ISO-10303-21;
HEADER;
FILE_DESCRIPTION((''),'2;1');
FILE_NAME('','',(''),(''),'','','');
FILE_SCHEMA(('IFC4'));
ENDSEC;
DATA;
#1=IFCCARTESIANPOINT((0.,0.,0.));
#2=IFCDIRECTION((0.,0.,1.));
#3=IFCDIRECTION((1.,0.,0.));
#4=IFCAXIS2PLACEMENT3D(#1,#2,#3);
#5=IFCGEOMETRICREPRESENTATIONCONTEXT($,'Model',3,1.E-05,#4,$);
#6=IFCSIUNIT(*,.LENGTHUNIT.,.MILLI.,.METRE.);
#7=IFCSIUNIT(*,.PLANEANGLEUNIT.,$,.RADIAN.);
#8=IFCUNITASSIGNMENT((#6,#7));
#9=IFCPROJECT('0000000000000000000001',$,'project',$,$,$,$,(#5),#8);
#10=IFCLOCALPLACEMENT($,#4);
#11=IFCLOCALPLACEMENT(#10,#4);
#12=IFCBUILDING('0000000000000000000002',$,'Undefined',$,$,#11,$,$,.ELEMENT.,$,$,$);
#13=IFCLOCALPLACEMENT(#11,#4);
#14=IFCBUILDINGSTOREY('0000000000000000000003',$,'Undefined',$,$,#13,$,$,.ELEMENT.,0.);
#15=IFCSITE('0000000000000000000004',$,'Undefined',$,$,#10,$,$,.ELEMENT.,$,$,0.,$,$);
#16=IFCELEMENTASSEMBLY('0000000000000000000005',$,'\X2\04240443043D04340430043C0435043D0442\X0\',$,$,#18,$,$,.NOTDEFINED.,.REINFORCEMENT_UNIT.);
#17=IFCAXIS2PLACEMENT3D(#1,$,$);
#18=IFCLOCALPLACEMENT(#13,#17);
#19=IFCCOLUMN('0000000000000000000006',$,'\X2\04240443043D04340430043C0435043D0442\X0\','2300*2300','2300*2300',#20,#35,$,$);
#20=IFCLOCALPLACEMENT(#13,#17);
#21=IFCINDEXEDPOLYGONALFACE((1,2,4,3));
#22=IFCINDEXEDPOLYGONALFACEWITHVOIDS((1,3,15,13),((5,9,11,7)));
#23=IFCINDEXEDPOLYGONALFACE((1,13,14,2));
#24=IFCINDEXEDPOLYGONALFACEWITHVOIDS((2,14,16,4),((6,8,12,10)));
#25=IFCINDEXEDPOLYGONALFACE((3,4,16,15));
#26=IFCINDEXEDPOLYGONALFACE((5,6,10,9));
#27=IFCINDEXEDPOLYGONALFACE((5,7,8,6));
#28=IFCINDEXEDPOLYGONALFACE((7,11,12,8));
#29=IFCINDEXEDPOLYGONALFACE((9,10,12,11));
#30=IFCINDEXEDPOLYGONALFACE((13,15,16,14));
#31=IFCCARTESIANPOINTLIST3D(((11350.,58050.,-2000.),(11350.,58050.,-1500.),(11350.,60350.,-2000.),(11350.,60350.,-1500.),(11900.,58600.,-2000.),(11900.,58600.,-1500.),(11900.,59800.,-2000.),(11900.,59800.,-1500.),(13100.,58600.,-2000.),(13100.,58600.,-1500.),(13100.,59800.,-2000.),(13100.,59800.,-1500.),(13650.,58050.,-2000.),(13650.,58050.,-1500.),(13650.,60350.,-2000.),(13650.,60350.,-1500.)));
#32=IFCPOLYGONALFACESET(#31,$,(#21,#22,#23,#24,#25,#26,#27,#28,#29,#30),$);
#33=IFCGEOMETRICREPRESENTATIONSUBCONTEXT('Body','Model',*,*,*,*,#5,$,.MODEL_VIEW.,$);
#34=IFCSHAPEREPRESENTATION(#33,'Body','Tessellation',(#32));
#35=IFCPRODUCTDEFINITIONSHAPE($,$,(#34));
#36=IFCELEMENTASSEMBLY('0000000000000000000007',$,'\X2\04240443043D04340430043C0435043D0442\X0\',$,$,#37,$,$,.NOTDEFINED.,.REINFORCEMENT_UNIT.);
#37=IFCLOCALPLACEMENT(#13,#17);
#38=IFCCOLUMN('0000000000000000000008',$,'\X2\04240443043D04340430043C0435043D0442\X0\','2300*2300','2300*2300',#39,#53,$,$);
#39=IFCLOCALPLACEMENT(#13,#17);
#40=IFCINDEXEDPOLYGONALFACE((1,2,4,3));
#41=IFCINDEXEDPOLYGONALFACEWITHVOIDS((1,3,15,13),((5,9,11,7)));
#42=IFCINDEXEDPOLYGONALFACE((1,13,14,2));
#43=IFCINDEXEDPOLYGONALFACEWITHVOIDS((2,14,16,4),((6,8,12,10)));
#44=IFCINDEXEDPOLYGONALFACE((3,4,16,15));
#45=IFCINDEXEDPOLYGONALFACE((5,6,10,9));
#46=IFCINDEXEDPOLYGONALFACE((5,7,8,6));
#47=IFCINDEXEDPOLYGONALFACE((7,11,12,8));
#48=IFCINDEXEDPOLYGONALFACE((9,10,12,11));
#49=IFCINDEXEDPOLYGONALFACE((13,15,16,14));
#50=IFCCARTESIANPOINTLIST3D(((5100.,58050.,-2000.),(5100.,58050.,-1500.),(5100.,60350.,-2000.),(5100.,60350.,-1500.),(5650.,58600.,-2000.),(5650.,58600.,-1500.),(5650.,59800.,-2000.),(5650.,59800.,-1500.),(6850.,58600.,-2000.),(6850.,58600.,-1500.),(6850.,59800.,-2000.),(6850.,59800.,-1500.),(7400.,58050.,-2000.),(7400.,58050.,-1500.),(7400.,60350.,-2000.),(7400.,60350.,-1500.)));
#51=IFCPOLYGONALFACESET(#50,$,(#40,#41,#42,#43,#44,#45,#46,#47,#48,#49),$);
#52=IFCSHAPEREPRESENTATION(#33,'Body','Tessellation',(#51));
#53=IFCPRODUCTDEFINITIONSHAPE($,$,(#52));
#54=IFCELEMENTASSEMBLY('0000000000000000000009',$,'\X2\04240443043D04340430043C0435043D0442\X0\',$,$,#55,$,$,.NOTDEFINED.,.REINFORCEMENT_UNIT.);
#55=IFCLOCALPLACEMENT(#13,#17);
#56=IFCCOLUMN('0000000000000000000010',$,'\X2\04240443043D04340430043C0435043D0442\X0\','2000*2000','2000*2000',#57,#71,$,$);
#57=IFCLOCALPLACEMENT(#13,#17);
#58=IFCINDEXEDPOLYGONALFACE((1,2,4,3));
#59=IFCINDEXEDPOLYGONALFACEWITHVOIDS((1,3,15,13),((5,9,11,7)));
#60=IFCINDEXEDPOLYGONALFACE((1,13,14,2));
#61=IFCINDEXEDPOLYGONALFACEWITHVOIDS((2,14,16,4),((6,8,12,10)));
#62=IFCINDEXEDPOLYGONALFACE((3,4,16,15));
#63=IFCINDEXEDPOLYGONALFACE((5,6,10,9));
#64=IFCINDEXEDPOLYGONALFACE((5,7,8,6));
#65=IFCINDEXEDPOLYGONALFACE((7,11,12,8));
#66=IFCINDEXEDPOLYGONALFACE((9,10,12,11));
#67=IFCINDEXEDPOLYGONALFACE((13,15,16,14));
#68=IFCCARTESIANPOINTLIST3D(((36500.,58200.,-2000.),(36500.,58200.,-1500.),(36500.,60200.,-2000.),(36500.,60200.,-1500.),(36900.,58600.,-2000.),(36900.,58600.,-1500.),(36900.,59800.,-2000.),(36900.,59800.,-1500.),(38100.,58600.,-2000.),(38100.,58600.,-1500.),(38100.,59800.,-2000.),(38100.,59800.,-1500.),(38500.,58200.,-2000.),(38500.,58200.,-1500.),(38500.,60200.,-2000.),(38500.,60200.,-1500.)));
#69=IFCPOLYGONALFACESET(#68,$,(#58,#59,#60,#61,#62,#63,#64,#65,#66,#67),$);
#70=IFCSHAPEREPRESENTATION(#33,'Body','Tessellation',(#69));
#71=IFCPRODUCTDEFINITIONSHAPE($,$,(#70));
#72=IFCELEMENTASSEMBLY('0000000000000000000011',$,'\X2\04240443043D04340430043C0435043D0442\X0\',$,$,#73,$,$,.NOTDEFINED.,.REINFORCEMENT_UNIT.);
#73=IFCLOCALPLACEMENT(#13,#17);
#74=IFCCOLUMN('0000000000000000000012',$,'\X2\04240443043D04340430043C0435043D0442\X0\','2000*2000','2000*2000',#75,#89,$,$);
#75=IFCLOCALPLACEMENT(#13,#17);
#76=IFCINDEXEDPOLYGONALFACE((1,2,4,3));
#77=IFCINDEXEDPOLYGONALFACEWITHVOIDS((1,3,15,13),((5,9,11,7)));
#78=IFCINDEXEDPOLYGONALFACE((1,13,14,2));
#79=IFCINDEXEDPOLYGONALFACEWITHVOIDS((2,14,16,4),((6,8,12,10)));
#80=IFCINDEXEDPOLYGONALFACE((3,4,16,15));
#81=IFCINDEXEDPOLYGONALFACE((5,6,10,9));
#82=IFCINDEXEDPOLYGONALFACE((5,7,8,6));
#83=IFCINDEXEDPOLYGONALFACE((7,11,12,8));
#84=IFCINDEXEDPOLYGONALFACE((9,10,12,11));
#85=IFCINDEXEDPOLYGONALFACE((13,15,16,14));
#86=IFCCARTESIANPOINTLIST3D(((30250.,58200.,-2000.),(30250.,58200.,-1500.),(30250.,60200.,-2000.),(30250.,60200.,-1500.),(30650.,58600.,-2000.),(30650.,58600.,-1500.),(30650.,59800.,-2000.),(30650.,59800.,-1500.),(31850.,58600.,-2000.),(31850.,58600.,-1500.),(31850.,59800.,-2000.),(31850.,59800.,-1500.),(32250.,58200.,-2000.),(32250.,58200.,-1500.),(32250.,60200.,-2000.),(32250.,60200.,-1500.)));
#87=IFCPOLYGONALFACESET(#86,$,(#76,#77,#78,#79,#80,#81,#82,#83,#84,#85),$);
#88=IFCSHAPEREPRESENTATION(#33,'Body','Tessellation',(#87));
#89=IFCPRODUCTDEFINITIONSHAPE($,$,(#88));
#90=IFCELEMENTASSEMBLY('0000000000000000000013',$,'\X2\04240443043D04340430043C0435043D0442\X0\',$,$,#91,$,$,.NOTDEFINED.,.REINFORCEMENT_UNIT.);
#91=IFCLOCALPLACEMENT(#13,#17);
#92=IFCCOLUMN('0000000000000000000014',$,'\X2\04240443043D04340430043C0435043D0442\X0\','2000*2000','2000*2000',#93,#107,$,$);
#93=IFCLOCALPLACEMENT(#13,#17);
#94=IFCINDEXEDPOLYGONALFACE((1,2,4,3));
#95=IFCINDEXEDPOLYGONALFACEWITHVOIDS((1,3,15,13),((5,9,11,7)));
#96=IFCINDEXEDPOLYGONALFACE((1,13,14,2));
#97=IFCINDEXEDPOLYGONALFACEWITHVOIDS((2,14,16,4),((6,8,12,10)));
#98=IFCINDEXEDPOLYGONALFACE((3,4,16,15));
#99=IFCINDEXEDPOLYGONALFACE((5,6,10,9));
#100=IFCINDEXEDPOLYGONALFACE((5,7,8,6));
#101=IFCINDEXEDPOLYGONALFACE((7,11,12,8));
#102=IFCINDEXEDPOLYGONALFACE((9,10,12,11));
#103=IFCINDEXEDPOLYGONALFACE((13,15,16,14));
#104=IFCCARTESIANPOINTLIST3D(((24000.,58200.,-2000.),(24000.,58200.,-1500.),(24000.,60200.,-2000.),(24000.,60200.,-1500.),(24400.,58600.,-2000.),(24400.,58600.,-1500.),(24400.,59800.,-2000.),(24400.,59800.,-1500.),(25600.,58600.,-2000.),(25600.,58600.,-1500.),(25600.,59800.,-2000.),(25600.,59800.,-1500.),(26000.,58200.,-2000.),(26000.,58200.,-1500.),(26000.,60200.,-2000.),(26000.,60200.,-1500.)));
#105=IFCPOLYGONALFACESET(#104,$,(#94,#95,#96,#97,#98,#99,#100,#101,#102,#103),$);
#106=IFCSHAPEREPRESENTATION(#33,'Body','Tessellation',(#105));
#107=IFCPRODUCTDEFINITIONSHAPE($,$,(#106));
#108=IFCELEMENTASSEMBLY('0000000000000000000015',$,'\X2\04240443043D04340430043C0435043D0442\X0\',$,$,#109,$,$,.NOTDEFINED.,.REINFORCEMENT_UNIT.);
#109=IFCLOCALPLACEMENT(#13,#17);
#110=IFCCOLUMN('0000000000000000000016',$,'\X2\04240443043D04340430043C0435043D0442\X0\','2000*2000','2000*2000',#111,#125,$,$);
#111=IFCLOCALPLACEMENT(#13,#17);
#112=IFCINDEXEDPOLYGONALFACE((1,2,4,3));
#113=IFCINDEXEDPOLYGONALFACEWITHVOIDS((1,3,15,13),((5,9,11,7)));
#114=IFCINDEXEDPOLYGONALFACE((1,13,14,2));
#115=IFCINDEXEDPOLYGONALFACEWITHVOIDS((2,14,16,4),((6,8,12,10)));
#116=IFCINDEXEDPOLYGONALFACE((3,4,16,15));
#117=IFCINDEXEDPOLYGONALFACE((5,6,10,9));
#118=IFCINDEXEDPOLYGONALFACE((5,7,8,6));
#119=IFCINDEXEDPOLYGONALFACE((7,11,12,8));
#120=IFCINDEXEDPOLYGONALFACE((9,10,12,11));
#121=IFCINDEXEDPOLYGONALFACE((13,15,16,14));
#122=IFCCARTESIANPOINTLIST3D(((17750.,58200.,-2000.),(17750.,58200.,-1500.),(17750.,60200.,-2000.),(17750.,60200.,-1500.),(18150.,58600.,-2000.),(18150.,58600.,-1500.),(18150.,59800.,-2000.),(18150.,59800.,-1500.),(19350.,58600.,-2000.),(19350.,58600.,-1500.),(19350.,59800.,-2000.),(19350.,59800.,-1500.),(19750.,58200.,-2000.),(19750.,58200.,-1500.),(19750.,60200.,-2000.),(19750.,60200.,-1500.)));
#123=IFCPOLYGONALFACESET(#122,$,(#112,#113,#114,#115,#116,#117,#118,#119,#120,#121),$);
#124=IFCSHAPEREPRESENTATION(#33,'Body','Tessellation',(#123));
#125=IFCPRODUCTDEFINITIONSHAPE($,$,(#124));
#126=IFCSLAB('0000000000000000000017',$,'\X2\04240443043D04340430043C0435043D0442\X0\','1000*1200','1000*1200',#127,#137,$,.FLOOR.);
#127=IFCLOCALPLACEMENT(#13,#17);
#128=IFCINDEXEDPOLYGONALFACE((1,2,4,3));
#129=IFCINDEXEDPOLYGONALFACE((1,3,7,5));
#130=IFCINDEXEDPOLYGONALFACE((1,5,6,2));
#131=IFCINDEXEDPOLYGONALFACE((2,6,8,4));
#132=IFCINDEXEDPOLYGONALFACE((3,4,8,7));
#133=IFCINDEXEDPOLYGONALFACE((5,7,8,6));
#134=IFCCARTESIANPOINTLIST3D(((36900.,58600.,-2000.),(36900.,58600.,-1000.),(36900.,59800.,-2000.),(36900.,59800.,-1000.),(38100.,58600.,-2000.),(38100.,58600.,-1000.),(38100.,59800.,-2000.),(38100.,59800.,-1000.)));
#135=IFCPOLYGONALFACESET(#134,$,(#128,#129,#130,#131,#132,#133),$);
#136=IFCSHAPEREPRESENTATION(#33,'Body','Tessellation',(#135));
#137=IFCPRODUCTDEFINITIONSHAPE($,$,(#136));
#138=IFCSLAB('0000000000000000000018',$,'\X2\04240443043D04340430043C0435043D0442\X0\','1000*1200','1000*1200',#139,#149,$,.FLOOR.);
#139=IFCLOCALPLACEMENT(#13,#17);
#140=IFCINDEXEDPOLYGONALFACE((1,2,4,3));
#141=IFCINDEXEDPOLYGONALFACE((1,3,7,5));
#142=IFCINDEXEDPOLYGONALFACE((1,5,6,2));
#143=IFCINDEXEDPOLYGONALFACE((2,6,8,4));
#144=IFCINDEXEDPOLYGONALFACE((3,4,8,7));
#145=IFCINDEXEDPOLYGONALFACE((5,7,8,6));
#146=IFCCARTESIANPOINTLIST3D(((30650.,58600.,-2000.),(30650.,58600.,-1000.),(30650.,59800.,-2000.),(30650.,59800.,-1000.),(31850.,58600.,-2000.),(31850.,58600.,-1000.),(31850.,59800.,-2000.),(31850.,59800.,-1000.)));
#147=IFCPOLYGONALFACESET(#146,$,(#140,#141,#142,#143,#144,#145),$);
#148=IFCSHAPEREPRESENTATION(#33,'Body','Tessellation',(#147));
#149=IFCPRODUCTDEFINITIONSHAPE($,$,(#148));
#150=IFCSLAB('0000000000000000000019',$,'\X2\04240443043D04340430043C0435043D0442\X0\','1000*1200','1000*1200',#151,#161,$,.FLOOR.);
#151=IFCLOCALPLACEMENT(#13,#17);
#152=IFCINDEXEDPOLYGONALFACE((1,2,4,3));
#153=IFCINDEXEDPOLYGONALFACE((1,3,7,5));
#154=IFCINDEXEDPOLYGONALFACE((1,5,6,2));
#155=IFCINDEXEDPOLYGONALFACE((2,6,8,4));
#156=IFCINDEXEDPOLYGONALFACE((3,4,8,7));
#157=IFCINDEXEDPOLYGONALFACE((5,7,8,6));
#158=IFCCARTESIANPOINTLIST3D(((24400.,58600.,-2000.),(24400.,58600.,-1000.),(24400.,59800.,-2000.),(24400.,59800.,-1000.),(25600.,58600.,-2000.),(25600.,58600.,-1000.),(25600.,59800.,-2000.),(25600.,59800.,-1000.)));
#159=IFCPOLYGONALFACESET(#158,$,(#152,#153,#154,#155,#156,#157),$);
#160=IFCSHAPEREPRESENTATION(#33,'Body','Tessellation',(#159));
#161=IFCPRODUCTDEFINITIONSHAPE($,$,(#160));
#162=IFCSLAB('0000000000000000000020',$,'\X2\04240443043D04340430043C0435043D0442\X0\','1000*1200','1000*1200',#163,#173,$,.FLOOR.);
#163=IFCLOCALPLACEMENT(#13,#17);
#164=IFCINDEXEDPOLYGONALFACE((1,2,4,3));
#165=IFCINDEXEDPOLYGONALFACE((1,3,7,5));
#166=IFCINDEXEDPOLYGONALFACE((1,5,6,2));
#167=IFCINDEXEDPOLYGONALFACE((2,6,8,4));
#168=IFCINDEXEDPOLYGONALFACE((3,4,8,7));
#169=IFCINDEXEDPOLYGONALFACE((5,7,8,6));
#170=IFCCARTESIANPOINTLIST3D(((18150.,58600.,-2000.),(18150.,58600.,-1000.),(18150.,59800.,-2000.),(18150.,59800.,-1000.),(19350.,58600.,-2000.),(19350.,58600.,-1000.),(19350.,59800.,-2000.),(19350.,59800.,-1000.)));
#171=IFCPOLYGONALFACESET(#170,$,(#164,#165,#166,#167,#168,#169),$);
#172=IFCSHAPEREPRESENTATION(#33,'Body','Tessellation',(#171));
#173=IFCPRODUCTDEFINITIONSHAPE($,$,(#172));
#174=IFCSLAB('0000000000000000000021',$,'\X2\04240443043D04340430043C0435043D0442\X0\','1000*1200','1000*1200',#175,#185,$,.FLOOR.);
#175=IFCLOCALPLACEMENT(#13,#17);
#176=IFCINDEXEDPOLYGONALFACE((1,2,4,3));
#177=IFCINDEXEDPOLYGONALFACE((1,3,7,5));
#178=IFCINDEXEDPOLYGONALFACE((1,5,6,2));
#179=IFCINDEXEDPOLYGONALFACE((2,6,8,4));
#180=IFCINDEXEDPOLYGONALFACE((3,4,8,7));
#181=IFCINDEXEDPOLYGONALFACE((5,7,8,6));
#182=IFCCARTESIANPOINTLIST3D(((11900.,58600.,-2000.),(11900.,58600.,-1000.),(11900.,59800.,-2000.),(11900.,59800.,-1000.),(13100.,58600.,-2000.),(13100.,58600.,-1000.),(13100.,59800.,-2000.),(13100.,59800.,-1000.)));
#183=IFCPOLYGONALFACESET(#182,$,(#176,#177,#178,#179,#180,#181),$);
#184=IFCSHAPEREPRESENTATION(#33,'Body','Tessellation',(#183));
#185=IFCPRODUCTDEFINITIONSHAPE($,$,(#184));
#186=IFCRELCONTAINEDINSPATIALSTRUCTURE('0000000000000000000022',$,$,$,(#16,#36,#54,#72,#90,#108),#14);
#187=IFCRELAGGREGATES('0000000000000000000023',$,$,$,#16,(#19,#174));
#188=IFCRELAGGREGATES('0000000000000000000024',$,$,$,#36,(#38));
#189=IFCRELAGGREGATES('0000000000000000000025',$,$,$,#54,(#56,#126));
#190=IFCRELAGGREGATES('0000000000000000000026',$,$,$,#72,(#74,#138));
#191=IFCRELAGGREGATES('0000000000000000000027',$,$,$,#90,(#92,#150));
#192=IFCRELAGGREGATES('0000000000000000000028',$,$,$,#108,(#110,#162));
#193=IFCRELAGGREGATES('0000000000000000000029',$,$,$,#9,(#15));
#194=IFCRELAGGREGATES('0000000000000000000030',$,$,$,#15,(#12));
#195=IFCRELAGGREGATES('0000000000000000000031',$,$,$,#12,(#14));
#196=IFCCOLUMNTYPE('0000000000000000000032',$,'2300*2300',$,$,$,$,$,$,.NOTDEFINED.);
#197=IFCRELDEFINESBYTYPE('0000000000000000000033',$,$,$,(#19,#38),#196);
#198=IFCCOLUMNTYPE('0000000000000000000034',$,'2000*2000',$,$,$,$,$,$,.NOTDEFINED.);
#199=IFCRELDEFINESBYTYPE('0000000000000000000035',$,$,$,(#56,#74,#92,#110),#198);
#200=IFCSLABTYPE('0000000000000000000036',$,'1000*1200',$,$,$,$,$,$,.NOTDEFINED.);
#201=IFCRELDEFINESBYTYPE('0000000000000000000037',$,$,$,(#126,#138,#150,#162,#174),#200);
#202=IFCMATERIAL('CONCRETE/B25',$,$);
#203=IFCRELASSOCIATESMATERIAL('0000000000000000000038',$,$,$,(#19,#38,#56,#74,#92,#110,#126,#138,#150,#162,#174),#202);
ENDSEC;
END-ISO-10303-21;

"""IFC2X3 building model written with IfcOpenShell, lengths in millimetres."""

from ifc_helpers import new_model, si_unit, frame, origin_with_axes, origin_2d_with_axis, place, context, subcontext, project, spatial, polyline, rectangle, outline, extrude, boolean, material, type_object, element, aggregate, save


model = new_model("IFC2X3")

# Units and contexts
model_context = context("Model", 3, precision=1e-05, world=origin_with_axes())
body_context = subcontext(model_context, "Body", "Model", "MODEL_VIEW")
ifc_project = project(units=[si_unit("LENGTHUNIT", "METRE", prefix="MILLI"), si_unit("PLANEANGLEUNIT", "RADIAN")], contexts=[model_context])

# Site, building, storey
site_placement = place(None, origin_with_axes())
site = spatial("IfcSite", under=ifc_project, at=site_placement, Name="Undefined", CompositionType="ELEMENT", RefElevation=0.0)
building_placement = place(site_placement, origin_with_axes())
building = spatial("IfcBuilding", under=site, at=building_placement, Name="Undefined", CompositionType="ELEMENT")
storey_placement = place(building_placement, origin_with_axes())
storey = spatial("IfcBuildingStorey", under=building, at=storey_placement, Name="Undefined", CompositionType="ELEMENT", Elevation=0.0)

# Element assemblies, columns
assembly_1_placement = place(storey_placement, origin_with_axes())
assembly_1 = element("IfcElementAssembly", 1, at=assembly_1_placement, inside=storey, Name="Фундамент", AssemblyPlace="NOTDEFINED", PredefinedType="REINFORCEMENT_UNIT")
ifc_material_1 = material(Name="CONCRETE/B25")
column_type_1 = type_object("IfcColumnType", Name="2300*2300", PredefinedType="NOTDEFINED")
column_1_placement = place(assembly_1_placement, frame((12500.0, 59200.0, -2000.0), z_axis=(0.0, 0.0, 1.0), x_axis=(0.0, -1.0, 0.0)))
column_1 = element("IfcColumn", 2, at=column_1_placement, type_object=column_type_1, material=ifc_material_1, Name="Фундамент", Description="2300*2300", ObjectType="2300*2300", context=body_context, shape_type="CSG", body=[
    boolean("DIFFERENCE", extrude(rectangle(XDim=2300.0, YDim=2300.0, at=origin_2d_with_axis()), frame((0.0, 0.0, 500.0), z_axis=(0.0, 0.0, -1.0), x_axis=(0.0, 1.0, 0.0)), (0.0, 0.0, 1.0), 500.0), extrude(outline(polyline([(0.0, 0.0), (1200.0, 0.0), (1200.0, 1200.0), (0.0, 1200.0), (0.0, 0.0)])), frame((-600.0, -600.0, -100.0), z_axis=(0.0, 0.0, 1.0), x_axis=(1.0, 0.0, 0.0)), (0.0, 0.0, 1.0), 700.0)),
])
assembly_2_placement = place(storey_placement, origin_with_axes())
assembly_2 = element("IfcElementAssembly", 3, at=assembly_2_placement, inside=storey, Name="Фундамент", AssemblyPlace="NOTDEFINED", PredefinedType="REINFORCEMENT_UNIT")
column_2_placement = place(assembly_2_placement, frame((6250.0, 59200.0, -2000.0), z_axis=(0.0, 0.0, 1.0), x_axis=(0.0, -1.0, 0.0)))
column_2 = element("IfcColumn", 4, at=column_2_placement, type_object=column_type_1, material=ifc_material_1, Name="Фундамент", Description="2300*2300", ObjectType="2300*2300", context=body_context, shape_type="CSG", body=[
    boolean("DIFFERENCE", extrude(rectangle(XDim=2300.0, YDim=2300.0, at=origin_2d_with_axis()), frame((0.0, 0.0, 500.0), z_axis=(0.0, 0.0, -1.0), x_axis=(0.0, 1.0, 0.0)), (0.0, 0.0, 1.0), 500.0), extrude(outline(polyline([(0.0, 0.0), (1200.0, 0.0), (1200.0, 1200.0), (0.0, 1200.0), (0.0, 0.0)])), frame((-600.0, -600.0, -100.0), z_axis=(0.0, 0.0, 1.0), x_axis=(1.0, 0.0, 0.0)), (0.0, 0.0, 1.0), 700.0)),
])
assembly_3_placement = place(storey_placement, origin_with_axes())
assembly_3 = element("IfcElementAssembly", 5, at=assembly_3_placement, inside=storey, Name="Фундамент", AssemblyPlace="NOTDEFINED", PredefinedType="REINFORCEMENT_UNIT")
column_type_2 = type_object("IfcColumnType", Name="2000*2000", PredefinedType="NOTDEFINED")
column_3_placement = place(assembly_3_placement, frame((37500.0, 59200.0, -2000.0), z_axis=(0.0, 0.0, 1.0), x_axis=(0.0, -1.0, 0.0)))
column_3 = element("IfcColumn", 6, at=column_3_placement, type_object=column_type_2, material=ifc_material_1, Name="Фундамент", Description="2000*2000", ObjectType="2000*2000", context=body_context, shape_type="CSG", body=[
    boolean("DIFFERENCE", extrude(rectangle(XDim=2000.0, YDim=2000.0, at=origin_2d_with_axis()), frame((0.0, 0.0, 500.0), z_axis=(0.0, 0.0, -1.0), x_axis=(0.0, 1.0, 0.0)), (0.0, 0.0, 1.0), 500.0), extrude(outline(polyline([(0.0, 0.0), (1200.0, 0.0), (1200.0, 1200.0), (0.0, 1200.0), (0.0, 0.0)])), frame((-600.0, -600.0, -100.0), z_axis=(0.0, 0.0, 1.0), x_axis=(1.0, 0.0, 0.0)), (0.0, 0.0, 1.0), 700.0)),
])
assembly_4_placement = place(storey_placement, origin_with_axes())
assembly_4 = element("IfcElementAssembly", 7, at=assembly_4_placement, inside=storey, Name="Фундамент", AssemblyPlace="NOTDEFINED", PredefinedType="REINFORCEMENT_UNIT")
column_4_placement = place(assembly_4_placement, frame((31250.0, 59200.0, -2000.0), z_axis=(0.0, 0.0, 1.0), x_axis=(0.0, -1.0, 0.0)))
column_4 = element("IfcColumn", 8, at=column_4_placement, type_object=column_type_2, material=ifc_material_1, Name="Фундамент", Description="2000*2000", ObjectType="2000*2000", context=body_context, shape_type="CSG", body=[
    boolean("DIFFERENCE", extrude(rectangle(XDim=2000.0, YDim=2000.0, at=origin_2d_with_axis()), frame((0.0, 0.0, 500.0), z_axis=(0.0, 0.0, -1.0), x_axis=(0.0, 1.0, 0.0)), (0.0, 0.0, 1.0), 500.0), extrude(outline(polyline([(0.0, 0.0), (1200.0, 0.0), (1200.0, 1200.0), (0.0, 1200.0), (0.0, 0.0)])), frame((-600.0, -600.0, -100.0), z_axis=(0.0, 0.0, 1.0), x_axis=(1.0, 0.0, 0.0)), (0.0, 0.0, 1.0), 700.0)),
])
assembly_5_placement = place(storey_placement, origin_with_axes())
assembly_5 = element("IfcElementAssembly", 9, at=assembly_5_placement, inside=storey, Name="Фундамент", AssemblyPlace="NOTDEFINED", PredefinedType="REINFORCEMENT_UNIT")
column_5_placement = place(assembly_5_placement, frame((25000.0, 59200.0, -2000.0), z_axis=(0.0, 0.0, 1.0), x_axis=(0.0, -1.0, 0.0)))
column_5 = element("IfcColumn", 10, at=column_5_placement, type_object=column_type_2, material=ifc_material_1, Name="Фундамент", Description="2000*2000", ObjectType="2000*2000", context=body_context, shape_type="CSG", body=[
    boolean("DIFFERENCE", extrude(rectangle(XDim=2000.0, YDim=2000.0, at=origin_2d_with_axis()), frame((0.0, 0.0, 500.0), z_axis=(0.0, 0.0, -1.0), x_axis=(0.0, 1.0, 0.0)), (0.0, 0.0, 1.0), 500.0), extrude(outline(polyline([(0.0, 0.0), (1200.0, 0.0), (1200.0, 1200.0), (0.0, 1200.0), (0.0, 0.0)])), frame((-600.0, -600.0, -100.0), z_axis=(0.0, 0.0, 1.0), x_axis=(1.0, 0.0, 0.0)), (0.0, 0.0, 1.0), 700.0)),
])
assembly_6_placement = place(storey_placement, origin_with_axes())
assembly_6 = element("IfcElementAssembly", 11, at=assembly_6_placement, inside=storey, Name="Фундамент", AssemblyPlace="NOTDEFINED", PredefinedType="REINFORCEMENT_UNIT")
column_6_placement = place(assembly_6_placement, frame((18750.0, 59200.0, -2000.0), z_axis=(0.0, 0.0, 1.0), x_axis=(0.0, -1.0, 0.0)))
column_6 = element("IfcColumn", 12, at=column_6_placement, type_object=column_type_2, material=ifc_material_1, Name="Фундамент", Description="2000*2000", ObjectType="2000*2000", context=body_context, shape_type="CSG", body=[
    boolean("DIFFERENCE", extrude(rectangle(XDim=2000.0, YDim=2000.0, at=origin_2d_with_axis()), frame((0.0, 0.0, 500.0), z_axis=(0.0, 0.0, -1.0), x_axis=(0.0, 1.0, 0.0)), (0.0, 0.0, 1.0), 500.0), extrude(outline(polyline([(0.0, 0.0), (1200.0, 0.0), (1200.0, 1200.0), (0.0, 1200.0), (0.0, 0.0)])), frame((-600.0, -600.0, -100.0), z_axis=(0.0, 0.0, 1.0), x_axis=(1.0, 0.0, 0.0)), (0.0, 0.0, 1.0), 700.0)),
])

# Slabs
slab_type_1 = type_object("IfcSlabType", Name="1000*1200", PredefinedType="NOTDEFINED")
slab_1_placement = place(assembly_3_placement, frame((36900.0, 59800.0, -1500.0), z_axis=(0.0, 0.0, 1.0), x_axis=(0.0, -1.0, 0.0)))
slab_1 = element("IfcSlab", 13, at=slab_1_placement, type_object=slab_type_1, material=ifc_material_1, Name="Фундамент", Description="1000*1200", ObjectType="1000*1200", PredefinedType="FLOOR", context=body_context, shape_type="SweptSolid", body=[
    extrude(outline(polyline([(0.0, 0.0), (1200.0, 0.0), (1200.0, 1200.0), (0.0, 1200.0), (0.0, 0.0)])), frame((0.0, 0.0, -500.0), z_axis=(0.0, 0.0, 1.0), x_axis=(1.0, 0.0, 0.0)), (0.0, 0.0, 1.0), 1000.0),
])
slab_2_placement = place(assembly_4_placement, frame((30650.0, 59800.0, -1500.0), z_axis=(0.0, 0.0, 1.0), x_axis=(0.0, -1.0, 0.0)))
slab_2 = element("IfcSlab", 14, at=slab_2_placement, type_object=slab_type_1, material=ifc_material_1, Name="Фундамент", Description="1000*1200", ObjectType="1000*1200", PredefinedType="FLOOR", context=body_context, shape_type="SweptSolid", body=[
    extrude(outline(polyline([(0.0, 0.0), (1200.0, 0.0), (1200.0, 1200.0), (0.0, 1200.0), (0.0, 0.0)])), frame((0.0, 0.0, -500.0), z_axis=(0.0, 0.0, 1.0), x_axis=(1.0, 0.0, 0.0)), (0.0, 0.0, 1.0), 1000.0),
])
slab_3_placement = place(assembly_5_placement, frame((24400.0, 59800.0, -1500.0), z_axis=(0.0, 0.0, 1.0), x_axis=(0.0, -1.0, 0.0)))
slab_3 = element("IfcSlab", 15, at=slab_3_placement, type_object=slab_type_1, material=ifc_material_1, Name="Фундамент", Description="1000*1200", ObjectType="1000*1200", PredefinedType="FLOOR", context=body_context, shape_type="SweptSolid", body=[
    extrude(outline(polyline([(0.0, 0.0), (1200.0, 0.0), (1200.0, 1200.0), (0.0, 1200.0), (0.0, 0.0)])), frame((0.0, 0.0, -500.0), z_axis=(0.0, 0.0, 1.0), x_axis=(1.0, 0.0, 0.0)), (0.0, 0.0, 1.0), 1000.0),
])
slab_4_placement = place(assembly_6_placement, frame((18150.0, 59800.0, -1500.0), z_axis=(0.0, 0.0, 1.0), x_axis=(0.0, -1.0, 0.0)))
slab_4 = element("IfcSlab", 16, at=slab_4_placement, type_object=slab_type_1, material=ifc_material_1, Name="Фундамент", Description="1000*1200", ObjectType="1000*1200", PredefinedType="FLOOR", context=body_context, shape_type="SweptSolid", body=[
    extrude(outline(polyline([(0.0, 0.0), (1200.0, 0.0), (1200.0, 1200.0), (0.0, 1200.0), (0.0, 0.0)])), frame((0.0, 0.0, -500.0), z_axis=(0.0, 0.0, 1.0), x_axis=(1.0, 0.0, 0.0)), (0.0, 0.0, 1.0), 1000.0),
])
slab_5_placement = place(assembly_1_placement, frame((11900.0, 59800.0, -1500.0), z_axis=(0.0, 0.0, 1.0), x_axis=(0.0, -1.0, 0.0)))
slab_5 = element("IfcSlab", 17, at=slab_5_placement, type_object=slab_type_1, material=ifc_material_1, Name="Фундамент", Description="1000*1200", ObjectType="1000*1200", PredefinedType="FLOOR", context=body_context, shape_type="SweptSolid", body=[
    extrude(outline(polyline([(0.0, 0.0), (1200.0, 0.0), (1200.0, 1200.0), (0.0, 1200.0), (0.0, 0.0)])), frame((0.0, 0.0, -500.0), z_axis=(0.0, 0.0, 1.0), x_axis=(1.0, 0.0, 0.0)), (0.0, 0.0, 1.0), 1000.0),
])
aggregate(assembly_1, [column_1, slab_5])
aggregate(assembly_2, [column_2])
aggregate(assembly_3, [column_3, slab_1])
aggregate(assembly_4, [column_4, slab_2])
aggregate(assembly_5, [column_5, slab_3])
aggregate(assembly_6, [column_6, slab_4])

save(model, "model.ifc")
